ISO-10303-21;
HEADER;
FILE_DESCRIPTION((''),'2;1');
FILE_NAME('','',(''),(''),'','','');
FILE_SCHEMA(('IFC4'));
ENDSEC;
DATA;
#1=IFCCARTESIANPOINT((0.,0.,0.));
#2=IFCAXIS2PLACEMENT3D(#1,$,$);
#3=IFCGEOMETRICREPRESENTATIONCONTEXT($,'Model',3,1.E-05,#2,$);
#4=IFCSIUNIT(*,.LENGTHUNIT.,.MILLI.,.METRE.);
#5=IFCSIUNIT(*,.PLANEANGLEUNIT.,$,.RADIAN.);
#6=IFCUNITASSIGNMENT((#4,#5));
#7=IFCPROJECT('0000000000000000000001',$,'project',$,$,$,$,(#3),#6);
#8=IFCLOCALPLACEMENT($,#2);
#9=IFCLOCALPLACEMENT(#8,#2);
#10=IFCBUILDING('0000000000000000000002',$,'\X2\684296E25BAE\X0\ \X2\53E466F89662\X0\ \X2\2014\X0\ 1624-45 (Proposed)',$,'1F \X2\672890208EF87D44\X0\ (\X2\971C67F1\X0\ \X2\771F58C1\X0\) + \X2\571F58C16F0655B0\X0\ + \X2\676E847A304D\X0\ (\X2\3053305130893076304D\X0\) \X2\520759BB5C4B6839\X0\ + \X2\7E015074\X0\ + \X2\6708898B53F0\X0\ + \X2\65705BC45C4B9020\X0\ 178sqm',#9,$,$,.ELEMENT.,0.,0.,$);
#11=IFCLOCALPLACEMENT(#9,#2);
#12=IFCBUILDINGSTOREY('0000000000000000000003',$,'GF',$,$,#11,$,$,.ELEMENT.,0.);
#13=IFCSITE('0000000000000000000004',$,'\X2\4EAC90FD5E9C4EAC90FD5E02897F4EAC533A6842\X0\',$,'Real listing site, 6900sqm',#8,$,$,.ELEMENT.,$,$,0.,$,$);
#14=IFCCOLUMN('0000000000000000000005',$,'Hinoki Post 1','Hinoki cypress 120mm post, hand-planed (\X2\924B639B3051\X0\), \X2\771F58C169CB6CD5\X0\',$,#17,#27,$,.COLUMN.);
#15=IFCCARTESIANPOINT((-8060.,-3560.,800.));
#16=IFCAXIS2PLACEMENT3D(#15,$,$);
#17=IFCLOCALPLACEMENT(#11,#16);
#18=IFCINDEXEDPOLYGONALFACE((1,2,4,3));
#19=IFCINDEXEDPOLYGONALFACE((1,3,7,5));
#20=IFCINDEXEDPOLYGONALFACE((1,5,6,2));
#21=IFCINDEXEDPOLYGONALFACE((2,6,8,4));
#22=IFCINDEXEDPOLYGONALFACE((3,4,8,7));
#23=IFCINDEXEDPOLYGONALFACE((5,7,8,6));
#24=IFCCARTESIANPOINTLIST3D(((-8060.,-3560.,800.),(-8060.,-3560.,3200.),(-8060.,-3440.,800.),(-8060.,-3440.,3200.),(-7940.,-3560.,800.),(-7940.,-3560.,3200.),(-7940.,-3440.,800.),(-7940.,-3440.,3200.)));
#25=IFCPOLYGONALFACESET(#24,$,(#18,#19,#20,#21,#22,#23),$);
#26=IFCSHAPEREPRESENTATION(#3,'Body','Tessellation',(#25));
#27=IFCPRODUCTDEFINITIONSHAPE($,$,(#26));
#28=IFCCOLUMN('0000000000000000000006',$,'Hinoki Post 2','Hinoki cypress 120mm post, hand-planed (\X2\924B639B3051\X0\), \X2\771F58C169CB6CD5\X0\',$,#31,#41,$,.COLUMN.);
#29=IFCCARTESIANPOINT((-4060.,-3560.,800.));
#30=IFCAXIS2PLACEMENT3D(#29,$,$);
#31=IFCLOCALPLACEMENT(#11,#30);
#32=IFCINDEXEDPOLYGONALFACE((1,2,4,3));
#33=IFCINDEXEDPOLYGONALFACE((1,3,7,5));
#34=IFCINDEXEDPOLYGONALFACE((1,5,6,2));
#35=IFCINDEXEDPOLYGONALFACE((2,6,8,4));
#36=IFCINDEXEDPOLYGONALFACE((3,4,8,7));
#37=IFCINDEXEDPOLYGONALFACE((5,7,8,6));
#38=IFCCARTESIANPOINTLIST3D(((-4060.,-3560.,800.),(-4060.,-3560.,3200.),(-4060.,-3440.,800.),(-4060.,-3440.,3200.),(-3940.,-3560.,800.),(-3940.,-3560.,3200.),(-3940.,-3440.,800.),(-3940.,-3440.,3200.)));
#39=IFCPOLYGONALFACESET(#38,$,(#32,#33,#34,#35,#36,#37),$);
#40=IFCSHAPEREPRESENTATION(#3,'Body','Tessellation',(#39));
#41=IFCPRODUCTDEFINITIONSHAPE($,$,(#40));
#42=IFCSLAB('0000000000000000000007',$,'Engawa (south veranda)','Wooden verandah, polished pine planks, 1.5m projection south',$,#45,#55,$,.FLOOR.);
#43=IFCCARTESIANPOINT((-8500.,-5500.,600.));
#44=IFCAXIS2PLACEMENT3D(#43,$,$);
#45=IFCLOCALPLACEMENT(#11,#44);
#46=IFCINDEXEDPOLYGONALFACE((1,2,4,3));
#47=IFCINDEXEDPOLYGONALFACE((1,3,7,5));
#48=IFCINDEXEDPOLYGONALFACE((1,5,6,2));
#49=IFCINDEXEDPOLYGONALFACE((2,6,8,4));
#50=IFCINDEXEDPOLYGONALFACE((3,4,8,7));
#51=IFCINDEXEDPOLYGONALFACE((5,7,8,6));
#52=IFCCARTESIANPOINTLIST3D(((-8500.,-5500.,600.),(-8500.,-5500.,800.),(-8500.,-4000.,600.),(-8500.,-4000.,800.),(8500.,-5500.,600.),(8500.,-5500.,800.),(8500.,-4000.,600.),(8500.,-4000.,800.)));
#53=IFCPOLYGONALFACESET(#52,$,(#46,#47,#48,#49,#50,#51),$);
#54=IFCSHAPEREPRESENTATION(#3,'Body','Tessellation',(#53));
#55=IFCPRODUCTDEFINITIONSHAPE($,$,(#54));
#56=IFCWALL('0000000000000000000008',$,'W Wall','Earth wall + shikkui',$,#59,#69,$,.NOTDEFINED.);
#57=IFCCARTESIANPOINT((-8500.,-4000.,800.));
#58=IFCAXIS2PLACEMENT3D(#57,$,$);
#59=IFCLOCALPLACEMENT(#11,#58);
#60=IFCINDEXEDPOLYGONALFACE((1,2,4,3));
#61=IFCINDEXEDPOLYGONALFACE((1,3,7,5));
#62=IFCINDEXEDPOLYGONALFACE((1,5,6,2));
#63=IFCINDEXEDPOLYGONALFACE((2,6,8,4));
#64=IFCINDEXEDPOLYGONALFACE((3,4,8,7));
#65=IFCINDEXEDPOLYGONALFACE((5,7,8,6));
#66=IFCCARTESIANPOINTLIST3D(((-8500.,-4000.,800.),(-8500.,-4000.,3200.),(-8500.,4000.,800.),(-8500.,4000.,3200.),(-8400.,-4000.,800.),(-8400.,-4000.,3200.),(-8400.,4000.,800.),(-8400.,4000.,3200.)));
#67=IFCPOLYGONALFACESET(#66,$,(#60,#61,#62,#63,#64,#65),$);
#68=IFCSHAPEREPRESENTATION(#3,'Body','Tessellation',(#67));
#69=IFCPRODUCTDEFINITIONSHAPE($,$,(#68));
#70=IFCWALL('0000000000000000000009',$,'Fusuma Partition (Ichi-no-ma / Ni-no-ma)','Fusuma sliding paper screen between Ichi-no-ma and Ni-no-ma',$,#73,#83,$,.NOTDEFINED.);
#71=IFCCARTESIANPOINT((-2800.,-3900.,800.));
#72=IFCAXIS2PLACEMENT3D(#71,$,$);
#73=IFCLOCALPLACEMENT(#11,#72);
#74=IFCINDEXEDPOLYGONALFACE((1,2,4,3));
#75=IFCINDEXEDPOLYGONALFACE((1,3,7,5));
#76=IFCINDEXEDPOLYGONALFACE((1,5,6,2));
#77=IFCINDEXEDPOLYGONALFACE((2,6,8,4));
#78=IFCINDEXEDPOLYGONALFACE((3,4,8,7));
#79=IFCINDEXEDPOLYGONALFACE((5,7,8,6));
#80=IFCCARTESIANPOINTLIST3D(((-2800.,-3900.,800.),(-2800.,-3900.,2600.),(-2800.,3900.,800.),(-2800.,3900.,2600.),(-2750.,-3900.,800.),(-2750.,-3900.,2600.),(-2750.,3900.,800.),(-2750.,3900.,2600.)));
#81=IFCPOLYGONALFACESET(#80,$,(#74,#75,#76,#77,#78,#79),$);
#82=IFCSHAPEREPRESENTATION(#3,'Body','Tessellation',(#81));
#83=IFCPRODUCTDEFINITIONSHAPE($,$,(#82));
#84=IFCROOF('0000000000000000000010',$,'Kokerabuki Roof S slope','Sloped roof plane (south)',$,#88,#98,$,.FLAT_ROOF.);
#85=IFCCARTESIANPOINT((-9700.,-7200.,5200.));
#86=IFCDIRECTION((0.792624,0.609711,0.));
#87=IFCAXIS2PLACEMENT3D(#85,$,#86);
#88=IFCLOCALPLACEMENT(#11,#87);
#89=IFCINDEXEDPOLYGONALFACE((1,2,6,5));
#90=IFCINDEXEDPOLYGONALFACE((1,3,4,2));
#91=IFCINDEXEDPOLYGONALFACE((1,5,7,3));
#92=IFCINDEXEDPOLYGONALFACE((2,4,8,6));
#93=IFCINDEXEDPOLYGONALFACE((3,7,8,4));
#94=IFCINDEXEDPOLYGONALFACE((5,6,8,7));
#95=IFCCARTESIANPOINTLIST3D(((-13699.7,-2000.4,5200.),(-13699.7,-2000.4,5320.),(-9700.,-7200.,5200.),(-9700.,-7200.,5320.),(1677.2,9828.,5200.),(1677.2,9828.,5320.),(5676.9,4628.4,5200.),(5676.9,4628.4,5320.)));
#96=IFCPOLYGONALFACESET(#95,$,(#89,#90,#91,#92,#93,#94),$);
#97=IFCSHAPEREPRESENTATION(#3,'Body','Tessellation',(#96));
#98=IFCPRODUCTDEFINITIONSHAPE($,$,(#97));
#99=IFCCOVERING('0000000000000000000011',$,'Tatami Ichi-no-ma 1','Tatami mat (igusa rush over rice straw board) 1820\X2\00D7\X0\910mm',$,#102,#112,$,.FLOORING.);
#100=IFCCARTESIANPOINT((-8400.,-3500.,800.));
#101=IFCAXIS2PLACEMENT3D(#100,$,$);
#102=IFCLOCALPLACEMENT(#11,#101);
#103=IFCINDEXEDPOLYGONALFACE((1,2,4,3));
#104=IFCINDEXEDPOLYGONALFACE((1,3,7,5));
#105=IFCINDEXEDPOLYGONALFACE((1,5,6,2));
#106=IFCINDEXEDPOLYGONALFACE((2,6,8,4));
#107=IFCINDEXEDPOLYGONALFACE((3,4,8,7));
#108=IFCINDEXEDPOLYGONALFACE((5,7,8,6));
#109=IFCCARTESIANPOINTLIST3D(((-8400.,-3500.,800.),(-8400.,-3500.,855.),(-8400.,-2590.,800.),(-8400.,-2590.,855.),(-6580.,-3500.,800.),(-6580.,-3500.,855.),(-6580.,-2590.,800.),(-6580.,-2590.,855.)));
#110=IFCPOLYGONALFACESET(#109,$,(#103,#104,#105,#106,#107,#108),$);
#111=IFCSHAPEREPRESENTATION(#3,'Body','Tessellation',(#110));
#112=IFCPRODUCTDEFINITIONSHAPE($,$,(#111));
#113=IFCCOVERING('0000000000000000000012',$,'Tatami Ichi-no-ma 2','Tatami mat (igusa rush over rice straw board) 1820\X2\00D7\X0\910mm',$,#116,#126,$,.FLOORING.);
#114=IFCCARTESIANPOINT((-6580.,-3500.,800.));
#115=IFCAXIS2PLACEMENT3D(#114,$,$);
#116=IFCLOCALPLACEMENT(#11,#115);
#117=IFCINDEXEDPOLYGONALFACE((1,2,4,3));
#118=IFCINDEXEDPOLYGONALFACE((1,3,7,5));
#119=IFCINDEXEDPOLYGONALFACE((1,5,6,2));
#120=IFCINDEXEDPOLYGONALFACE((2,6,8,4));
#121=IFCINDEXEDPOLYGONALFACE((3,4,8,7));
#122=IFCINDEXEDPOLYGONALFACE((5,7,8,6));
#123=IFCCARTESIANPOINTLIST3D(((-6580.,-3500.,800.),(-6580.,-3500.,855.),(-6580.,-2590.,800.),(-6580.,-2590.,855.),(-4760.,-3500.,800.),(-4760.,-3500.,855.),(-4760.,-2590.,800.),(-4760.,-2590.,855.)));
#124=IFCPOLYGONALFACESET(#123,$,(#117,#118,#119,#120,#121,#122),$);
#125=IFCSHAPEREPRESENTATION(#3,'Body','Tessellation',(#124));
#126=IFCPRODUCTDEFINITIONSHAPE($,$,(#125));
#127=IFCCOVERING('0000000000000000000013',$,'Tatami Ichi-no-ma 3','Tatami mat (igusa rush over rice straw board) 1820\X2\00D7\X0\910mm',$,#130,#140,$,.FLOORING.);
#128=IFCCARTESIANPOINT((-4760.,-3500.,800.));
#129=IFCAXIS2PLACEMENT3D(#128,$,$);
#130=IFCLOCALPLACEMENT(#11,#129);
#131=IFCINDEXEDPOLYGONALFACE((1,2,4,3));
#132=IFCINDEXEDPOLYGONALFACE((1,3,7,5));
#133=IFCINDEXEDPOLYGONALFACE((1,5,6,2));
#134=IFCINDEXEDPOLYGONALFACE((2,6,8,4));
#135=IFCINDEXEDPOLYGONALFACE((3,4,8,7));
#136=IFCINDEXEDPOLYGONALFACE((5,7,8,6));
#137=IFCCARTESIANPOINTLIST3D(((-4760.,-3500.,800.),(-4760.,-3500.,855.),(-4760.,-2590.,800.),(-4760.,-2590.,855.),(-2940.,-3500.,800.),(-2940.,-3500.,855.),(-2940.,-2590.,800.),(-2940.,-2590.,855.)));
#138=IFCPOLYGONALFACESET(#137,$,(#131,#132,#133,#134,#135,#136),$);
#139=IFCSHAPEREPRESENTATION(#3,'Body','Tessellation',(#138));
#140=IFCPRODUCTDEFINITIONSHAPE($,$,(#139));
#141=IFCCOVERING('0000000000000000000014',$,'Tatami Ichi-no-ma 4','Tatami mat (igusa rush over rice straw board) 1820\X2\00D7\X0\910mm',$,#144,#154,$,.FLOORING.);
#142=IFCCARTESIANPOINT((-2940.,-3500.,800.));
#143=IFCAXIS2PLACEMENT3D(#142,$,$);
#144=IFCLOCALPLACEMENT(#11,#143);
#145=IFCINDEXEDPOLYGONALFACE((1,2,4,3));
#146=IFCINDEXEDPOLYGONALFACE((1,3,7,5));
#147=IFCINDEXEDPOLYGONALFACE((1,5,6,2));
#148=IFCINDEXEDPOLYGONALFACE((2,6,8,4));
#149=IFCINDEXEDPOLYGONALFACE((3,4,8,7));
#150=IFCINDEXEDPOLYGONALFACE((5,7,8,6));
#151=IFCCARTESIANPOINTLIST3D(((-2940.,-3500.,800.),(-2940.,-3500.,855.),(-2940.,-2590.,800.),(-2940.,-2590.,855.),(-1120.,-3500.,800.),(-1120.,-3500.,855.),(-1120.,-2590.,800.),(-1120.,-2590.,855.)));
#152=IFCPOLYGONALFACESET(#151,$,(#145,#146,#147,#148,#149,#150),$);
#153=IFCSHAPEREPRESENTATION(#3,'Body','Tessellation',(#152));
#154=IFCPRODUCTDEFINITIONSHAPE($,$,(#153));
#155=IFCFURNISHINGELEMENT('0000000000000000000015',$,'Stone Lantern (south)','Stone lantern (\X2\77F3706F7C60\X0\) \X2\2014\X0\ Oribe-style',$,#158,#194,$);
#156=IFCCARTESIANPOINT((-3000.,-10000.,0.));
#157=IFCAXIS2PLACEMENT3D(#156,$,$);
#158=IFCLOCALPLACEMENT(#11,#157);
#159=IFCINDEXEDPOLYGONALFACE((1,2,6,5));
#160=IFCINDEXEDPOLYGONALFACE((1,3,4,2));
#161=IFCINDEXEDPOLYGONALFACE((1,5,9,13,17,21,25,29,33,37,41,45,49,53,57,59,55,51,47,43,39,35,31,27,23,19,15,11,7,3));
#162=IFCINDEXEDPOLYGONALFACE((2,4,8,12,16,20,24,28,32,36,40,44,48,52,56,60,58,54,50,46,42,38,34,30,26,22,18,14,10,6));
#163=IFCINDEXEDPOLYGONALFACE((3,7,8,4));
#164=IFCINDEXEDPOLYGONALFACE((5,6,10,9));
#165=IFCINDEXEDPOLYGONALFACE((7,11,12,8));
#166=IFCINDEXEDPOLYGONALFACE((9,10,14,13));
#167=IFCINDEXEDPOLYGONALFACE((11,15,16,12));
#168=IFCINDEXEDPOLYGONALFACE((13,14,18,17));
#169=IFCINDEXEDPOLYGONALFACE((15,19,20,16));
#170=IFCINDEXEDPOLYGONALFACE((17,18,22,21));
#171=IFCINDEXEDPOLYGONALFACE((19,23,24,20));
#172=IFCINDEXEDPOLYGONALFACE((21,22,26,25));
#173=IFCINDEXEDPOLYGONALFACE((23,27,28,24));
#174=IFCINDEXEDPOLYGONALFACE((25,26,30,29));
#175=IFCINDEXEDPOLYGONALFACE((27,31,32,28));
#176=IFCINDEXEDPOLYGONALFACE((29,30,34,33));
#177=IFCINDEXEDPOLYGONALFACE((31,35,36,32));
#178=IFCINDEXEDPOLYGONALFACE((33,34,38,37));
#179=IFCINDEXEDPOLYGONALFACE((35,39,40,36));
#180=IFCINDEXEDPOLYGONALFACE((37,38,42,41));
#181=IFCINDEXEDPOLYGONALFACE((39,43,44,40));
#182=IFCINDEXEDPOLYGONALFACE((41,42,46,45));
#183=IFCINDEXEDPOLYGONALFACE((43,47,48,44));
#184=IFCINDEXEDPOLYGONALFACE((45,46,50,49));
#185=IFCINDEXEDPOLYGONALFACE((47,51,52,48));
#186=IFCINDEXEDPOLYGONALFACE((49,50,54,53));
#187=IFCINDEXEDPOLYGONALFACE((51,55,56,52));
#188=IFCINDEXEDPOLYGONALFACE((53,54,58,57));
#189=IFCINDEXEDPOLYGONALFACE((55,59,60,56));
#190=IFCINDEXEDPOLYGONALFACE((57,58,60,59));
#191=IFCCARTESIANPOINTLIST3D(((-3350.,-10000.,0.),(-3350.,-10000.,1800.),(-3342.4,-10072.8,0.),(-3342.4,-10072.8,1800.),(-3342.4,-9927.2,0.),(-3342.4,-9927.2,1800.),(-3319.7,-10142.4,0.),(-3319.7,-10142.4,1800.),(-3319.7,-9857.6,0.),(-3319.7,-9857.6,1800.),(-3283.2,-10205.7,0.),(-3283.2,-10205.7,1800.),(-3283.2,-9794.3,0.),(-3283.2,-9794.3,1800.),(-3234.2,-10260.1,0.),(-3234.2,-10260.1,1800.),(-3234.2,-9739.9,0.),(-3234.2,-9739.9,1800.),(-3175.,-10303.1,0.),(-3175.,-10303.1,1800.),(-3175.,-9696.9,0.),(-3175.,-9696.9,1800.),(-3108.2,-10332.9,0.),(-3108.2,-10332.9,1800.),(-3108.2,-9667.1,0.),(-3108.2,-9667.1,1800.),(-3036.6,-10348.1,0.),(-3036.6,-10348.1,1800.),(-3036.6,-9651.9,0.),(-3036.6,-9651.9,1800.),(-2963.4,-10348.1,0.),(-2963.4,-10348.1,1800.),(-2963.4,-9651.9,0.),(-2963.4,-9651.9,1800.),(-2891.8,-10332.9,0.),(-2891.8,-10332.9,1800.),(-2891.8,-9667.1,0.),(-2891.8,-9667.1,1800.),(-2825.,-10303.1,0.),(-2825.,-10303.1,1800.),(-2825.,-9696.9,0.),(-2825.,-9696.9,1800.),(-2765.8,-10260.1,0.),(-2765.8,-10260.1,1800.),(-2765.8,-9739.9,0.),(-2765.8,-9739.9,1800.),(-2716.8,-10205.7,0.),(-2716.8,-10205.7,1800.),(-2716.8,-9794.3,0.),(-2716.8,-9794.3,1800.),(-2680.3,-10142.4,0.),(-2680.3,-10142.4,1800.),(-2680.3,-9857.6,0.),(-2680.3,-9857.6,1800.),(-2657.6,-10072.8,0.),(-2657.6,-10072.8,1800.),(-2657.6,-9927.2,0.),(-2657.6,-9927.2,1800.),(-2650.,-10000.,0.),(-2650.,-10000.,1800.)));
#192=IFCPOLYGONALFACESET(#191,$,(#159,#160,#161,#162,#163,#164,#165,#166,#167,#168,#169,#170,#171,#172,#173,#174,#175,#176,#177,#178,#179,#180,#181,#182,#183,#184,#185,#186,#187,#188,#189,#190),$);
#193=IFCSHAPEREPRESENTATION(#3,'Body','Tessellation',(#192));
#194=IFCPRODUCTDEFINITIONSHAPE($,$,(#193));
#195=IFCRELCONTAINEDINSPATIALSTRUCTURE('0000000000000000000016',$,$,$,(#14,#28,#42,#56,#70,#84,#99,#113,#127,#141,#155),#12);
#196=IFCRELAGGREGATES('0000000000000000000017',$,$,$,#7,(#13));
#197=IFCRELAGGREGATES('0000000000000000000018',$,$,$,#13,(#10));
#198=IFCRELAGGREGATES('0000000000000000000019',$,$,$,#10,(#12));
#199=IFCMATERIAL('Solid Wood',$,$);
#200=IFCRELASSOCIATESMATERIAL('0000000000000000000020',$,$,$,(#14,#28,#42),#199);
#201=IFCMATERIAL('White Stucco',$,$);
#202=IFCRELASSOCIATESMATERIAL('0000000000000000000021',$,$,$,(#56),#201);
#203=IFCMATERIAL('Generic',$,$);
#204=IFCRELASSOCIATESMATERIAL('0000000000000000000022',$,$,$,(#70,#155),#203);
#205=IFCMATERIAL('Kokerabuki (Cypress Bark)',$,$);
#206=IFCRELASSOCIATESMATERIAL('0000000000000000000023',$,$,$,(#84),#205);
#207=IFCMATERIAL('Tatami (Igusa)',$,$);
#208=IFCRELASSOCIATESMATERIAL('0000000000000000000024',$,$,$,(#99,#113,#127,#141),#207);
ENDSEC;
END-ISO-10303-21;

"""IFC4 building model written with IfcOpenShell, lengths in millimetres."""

from ifc_helpers import new_model, si_unit, frame, frame_2d, origin, origin_2d, place, context, project, spatial, rectangle, circle, extrude, material, element, save


model = new_model("IFC4")

# Units and contexts
model_context = context("Model", 3, precision=1e-05, world=origin())
ifc_project = project(units=[si_unit("LENGTHUNIT", "METRE", prefix="MILLI"), si_unit("PLANEANGLEUNIT", "RADIAN")], contexts=[model_context])

# Site, building, storey
site_placement = place(None, origin())
site = spatial("IfcSite", under=ifc_project, at=site_placement, Name="京都府京都市西京区桂", ObjectType="Real listing site, 6900sqm", CompositionType="ELEMENT", RefElevation=0.0)
building_placement = place(site_placement, origin())
building = spatial("IfcBuilding", under=site, at=building_placement, Name="桂離宮 古書院 — 1624-45 (Proposed)", ObjectType="1F 木造軸組 (霜柱 真壁) + 土壁漆喰 + 杮葺き (こけらぶき) 切妻屋根 + 縁側 + 月見台 + 数寄屋造 178sqm", CompositionType="ELEMENT", ElevationOfRefHeight=0.0, ElevationOfTerrain=0.0)
storey_placement = place(building_placement, origin())
storey = spatial("IfcBuildingStorey", under=building, at=storey_placement, Name="GF", CompositionType="ELEMENT", Elevation=0.0)

# Columns
ifc_material_1 = material(Name="Solid Wood")
column_1_placement = place(storey_placement, frame((-8060.0, -3560.0, 800.0)))
element("IfcColumn", 1, at=column_1_placement, inside=storey, material=ifc_material_1, Name="Hinoki Post 1", Description="Hinoki cypress 120mm post, hand-planed (鉋掛け), 真壁構法", PredefinedType="COLUMN", context=model_context, shape_type="SweptSolid", body=[
    extrude(rectangle(XDim=120.0, YDim=120.0, at=frame_2d((60.0, 60.0))), frame((-8060.0, -3560.0, 800.0)), (0.0, 0.0, 1.0), 2400.0),
])
column_2_placement = place(storey_placement, frame((-4060.0, -3560.0, 800.0)))
element("IfcColumn", 2, at=column_2_placement, inside=storey, material=ifc_material_1, Name="Hinoki Post 2", Description="Hinoki cypress 120mm post, hand-planed (鉋掛け), 真壁構法", PredefinedType="COLUMN", context=model_context, shape_type="SweptSolid", body=[
    extrude(rectangle(XDim=120.0, YDim=120.0, at=frame_2d((60.0, 60.0))), frame((-4060.0, -3560.0, 800.0)), (0.0, 0.0, 1.0), 2400.0),
])

# Slab
slab_1_placement = place(storey_placement, frame((-8500.0, -5500.0, 600.0)))
element("IfcSlab", 3, at=slab_1_placement, inside=storey, material=ifc_material_1, Name="Engawa (south veranda)", Description="Wooden verandah, polished pine planks, 1.5m projection south", PredefinedType="FLOOR", context=model_context, shape_type="SweptSolid", body=[
    extrude(rectangle(XDim=17000.0, YDim=1500.0, at=frame_2d((8500.0, 750.0))), frame((-8500.0, -5500.0, 600.0)), (0.0, 0.0, 1.0), 200.0),
])

# Shared definitions
ifc_material_2 = material(Name="White Stucco")

# Walls
wall_1_placement = place(storey_placement, frame((-8500.0, -4000.0, 800.0)))
element("IfcWall", 4, at=wall_1_placement, inside=storey, material=ifc_material_2, Name="W Wall", Description="Earth wall + shikkui", PredefinedType="NOTDEFINED", context=model_context, shape_type="SweptSolid", body=[
    extrude(rectangle(XDim=100.0, YDim=8000.0, at=frame_2d((50.0, 4000.0))), frame((-8500.0, -4000.0, 800.0)), (0.0, 0.0, 1.0), 2400.0),
])
ifc_material_3 = material(Name="Generic")
wall_2_placement = place(storey_placement, frame((-2800.0, -3900.0, 800.0)))
element("IfcWall", 5, at=wall_2_placement, inside=storey, material=ifc_material_3, Name="Fusuma Partition (Ichi-no-ma / Ni-no-ma)", Description="Fusuma sliding paper screen between Ichi-no-ma and Ni-no-ma", PredefinedType="NOTDEFINED", context=model_context, shape_type="SweptSolid", body=[
    extrude(rectangle(XDim=50.0, YDim=7800.0, at=frame_2d((25.0, 3900.0))), frame((-2800.0, -3900.0, 800.0)), (0.0, 0.0, 1.0), 1800.0),
])

# Roof
ifc_material_4 = material(Name="Kokerabuki (Cypress Bark)")
roof_placement = place(storey_placement, frame((-9700.0, -7200.0, 5200.0), x_axis=(0.792624, 0.609711, 0.0)))
element("IfcRoof", 6, at=roof_placement, inside=storey, material=ifc_material_4, Name="Kokerabuki Roof S slope", Description="Sloped roof plane (south)", PredefinedType="FLAT_ROOF", context=model_context, shape_type="SweptSolid", body=[
    extrude(rectangle(XDim=19400.0, YDim=6560.0, at=frame_2d((9700.0, 3280.0))), frame((-9700.0, -7200.0, 5200.0), x_axis=(0.792624, 0.609711, 0.0)), (0.0, 0.0, 1.0), 120.0),
])

# Coverings
ifc_material_5 = material(Name="Tatami (Igusa)")
covering_1_placement = place(storey_placement, frame((-8400.0, -3500.0, 800.0)))
element("IfcCovering", 7, at=covering_1_placement, inside=storey, material=ifc_material_5, Name="Tatami Ichi-no-ma 1", Description="Tatami mat (igusa rush over rice straw board) 1820×910mm", PredefinedType="FLOORING", context=model_context, shape_type="SweptSolid", body=[
    extrude(rectangle(XDim=1820.0, YDim=910.0, at=frame_2d((910.0, 455.0))), frame((-8400.0, -3500.0, 800.0)), (0.0, 0.0, 1.0), 55.0),
])
covering_2_placement = place(storey_placement, frame((-6580.0, -3500.0, 800.0)))
element("IfcCovering", 8, at=covering_2_placement, inside=storey, material=ifc_material_5, Name="Tatami Ichi-no-ma 2", Description="Tatami mat (igusa rush over rice straw board) 1820×910mm", PredefinedType="FLOORING", context=model_context, shape_type="SweptSolid", body=[
    extrude(rectangle(XDim=1820.0, YDim=910.0, at=frame_2d((910.0, 455.0))), frame((-6580.0, -3500.0, 800.0)), (0.0, 0.0, 1.0), 55.0),
])
covering_3_placement = place(storey_placement, frame((-4760.0, -3500.0, 800.0)))
element("IfcCovering", 9, at=covering_3_placement, inside=storey, material=ifc_material_5, Name="Tatami Ichi-no-ma 3", Description="Tatami mat (igusa rush over rice straw board) 1820×910mm", PredefinedType="FLOORING", context=model_context, shape_type="SweptSolid", body=[
    extrude(rectangle(XDim=1820.0, YDim=910.0, at=frame_2d((910.0, 455.0))), frame((-4760.0, -3500.0, 800.0)), (0.0, 0.0, 1.0), 55.0),
])
covering_4_placement = place(storey_placement, frame((-2940.0, -3500.0, 800.0)))
element("IfcCovering", 10, at=covering_4_placement, inside=storey, material=ifc_material_5, Name="Tatami Ichi-no-ma 4", Description="Tatami mat (igusa rush over rice straw board) 1820×910mm", PredefinedType="FLOORING", context=model_context, shape_type="SweptSolid", body=[
    extrude(rectangle(XDim=1820.0, YDim=910.0, at=frame_2d((910.0, 455.0))), frame((-2940.0, -3500.0, 800.0)), (0.0, 0.0, 1.0), 55.0),
])

# Furnishing element
furnishing_placement = place(storey_placement, frame((-3000.0, -10000.0, 0.0)))
element("IfcFurnishingElement", 11, at=furnishing_placement, inside=storey, material=ifc_material_3, Name="Stone Lantern (south)", Description="Stone lantern (石灯籠) — Oribe-style", context=model_context, shape_type="SweptSolid", body=[
    extrude(circle(Radius=350.0, at=origin_2d()), frame((-3000.0, -10000.0, 0.0)), (0.0, 0.0, 1.0), 1800.0),
])

save(model, "model.ifc")
